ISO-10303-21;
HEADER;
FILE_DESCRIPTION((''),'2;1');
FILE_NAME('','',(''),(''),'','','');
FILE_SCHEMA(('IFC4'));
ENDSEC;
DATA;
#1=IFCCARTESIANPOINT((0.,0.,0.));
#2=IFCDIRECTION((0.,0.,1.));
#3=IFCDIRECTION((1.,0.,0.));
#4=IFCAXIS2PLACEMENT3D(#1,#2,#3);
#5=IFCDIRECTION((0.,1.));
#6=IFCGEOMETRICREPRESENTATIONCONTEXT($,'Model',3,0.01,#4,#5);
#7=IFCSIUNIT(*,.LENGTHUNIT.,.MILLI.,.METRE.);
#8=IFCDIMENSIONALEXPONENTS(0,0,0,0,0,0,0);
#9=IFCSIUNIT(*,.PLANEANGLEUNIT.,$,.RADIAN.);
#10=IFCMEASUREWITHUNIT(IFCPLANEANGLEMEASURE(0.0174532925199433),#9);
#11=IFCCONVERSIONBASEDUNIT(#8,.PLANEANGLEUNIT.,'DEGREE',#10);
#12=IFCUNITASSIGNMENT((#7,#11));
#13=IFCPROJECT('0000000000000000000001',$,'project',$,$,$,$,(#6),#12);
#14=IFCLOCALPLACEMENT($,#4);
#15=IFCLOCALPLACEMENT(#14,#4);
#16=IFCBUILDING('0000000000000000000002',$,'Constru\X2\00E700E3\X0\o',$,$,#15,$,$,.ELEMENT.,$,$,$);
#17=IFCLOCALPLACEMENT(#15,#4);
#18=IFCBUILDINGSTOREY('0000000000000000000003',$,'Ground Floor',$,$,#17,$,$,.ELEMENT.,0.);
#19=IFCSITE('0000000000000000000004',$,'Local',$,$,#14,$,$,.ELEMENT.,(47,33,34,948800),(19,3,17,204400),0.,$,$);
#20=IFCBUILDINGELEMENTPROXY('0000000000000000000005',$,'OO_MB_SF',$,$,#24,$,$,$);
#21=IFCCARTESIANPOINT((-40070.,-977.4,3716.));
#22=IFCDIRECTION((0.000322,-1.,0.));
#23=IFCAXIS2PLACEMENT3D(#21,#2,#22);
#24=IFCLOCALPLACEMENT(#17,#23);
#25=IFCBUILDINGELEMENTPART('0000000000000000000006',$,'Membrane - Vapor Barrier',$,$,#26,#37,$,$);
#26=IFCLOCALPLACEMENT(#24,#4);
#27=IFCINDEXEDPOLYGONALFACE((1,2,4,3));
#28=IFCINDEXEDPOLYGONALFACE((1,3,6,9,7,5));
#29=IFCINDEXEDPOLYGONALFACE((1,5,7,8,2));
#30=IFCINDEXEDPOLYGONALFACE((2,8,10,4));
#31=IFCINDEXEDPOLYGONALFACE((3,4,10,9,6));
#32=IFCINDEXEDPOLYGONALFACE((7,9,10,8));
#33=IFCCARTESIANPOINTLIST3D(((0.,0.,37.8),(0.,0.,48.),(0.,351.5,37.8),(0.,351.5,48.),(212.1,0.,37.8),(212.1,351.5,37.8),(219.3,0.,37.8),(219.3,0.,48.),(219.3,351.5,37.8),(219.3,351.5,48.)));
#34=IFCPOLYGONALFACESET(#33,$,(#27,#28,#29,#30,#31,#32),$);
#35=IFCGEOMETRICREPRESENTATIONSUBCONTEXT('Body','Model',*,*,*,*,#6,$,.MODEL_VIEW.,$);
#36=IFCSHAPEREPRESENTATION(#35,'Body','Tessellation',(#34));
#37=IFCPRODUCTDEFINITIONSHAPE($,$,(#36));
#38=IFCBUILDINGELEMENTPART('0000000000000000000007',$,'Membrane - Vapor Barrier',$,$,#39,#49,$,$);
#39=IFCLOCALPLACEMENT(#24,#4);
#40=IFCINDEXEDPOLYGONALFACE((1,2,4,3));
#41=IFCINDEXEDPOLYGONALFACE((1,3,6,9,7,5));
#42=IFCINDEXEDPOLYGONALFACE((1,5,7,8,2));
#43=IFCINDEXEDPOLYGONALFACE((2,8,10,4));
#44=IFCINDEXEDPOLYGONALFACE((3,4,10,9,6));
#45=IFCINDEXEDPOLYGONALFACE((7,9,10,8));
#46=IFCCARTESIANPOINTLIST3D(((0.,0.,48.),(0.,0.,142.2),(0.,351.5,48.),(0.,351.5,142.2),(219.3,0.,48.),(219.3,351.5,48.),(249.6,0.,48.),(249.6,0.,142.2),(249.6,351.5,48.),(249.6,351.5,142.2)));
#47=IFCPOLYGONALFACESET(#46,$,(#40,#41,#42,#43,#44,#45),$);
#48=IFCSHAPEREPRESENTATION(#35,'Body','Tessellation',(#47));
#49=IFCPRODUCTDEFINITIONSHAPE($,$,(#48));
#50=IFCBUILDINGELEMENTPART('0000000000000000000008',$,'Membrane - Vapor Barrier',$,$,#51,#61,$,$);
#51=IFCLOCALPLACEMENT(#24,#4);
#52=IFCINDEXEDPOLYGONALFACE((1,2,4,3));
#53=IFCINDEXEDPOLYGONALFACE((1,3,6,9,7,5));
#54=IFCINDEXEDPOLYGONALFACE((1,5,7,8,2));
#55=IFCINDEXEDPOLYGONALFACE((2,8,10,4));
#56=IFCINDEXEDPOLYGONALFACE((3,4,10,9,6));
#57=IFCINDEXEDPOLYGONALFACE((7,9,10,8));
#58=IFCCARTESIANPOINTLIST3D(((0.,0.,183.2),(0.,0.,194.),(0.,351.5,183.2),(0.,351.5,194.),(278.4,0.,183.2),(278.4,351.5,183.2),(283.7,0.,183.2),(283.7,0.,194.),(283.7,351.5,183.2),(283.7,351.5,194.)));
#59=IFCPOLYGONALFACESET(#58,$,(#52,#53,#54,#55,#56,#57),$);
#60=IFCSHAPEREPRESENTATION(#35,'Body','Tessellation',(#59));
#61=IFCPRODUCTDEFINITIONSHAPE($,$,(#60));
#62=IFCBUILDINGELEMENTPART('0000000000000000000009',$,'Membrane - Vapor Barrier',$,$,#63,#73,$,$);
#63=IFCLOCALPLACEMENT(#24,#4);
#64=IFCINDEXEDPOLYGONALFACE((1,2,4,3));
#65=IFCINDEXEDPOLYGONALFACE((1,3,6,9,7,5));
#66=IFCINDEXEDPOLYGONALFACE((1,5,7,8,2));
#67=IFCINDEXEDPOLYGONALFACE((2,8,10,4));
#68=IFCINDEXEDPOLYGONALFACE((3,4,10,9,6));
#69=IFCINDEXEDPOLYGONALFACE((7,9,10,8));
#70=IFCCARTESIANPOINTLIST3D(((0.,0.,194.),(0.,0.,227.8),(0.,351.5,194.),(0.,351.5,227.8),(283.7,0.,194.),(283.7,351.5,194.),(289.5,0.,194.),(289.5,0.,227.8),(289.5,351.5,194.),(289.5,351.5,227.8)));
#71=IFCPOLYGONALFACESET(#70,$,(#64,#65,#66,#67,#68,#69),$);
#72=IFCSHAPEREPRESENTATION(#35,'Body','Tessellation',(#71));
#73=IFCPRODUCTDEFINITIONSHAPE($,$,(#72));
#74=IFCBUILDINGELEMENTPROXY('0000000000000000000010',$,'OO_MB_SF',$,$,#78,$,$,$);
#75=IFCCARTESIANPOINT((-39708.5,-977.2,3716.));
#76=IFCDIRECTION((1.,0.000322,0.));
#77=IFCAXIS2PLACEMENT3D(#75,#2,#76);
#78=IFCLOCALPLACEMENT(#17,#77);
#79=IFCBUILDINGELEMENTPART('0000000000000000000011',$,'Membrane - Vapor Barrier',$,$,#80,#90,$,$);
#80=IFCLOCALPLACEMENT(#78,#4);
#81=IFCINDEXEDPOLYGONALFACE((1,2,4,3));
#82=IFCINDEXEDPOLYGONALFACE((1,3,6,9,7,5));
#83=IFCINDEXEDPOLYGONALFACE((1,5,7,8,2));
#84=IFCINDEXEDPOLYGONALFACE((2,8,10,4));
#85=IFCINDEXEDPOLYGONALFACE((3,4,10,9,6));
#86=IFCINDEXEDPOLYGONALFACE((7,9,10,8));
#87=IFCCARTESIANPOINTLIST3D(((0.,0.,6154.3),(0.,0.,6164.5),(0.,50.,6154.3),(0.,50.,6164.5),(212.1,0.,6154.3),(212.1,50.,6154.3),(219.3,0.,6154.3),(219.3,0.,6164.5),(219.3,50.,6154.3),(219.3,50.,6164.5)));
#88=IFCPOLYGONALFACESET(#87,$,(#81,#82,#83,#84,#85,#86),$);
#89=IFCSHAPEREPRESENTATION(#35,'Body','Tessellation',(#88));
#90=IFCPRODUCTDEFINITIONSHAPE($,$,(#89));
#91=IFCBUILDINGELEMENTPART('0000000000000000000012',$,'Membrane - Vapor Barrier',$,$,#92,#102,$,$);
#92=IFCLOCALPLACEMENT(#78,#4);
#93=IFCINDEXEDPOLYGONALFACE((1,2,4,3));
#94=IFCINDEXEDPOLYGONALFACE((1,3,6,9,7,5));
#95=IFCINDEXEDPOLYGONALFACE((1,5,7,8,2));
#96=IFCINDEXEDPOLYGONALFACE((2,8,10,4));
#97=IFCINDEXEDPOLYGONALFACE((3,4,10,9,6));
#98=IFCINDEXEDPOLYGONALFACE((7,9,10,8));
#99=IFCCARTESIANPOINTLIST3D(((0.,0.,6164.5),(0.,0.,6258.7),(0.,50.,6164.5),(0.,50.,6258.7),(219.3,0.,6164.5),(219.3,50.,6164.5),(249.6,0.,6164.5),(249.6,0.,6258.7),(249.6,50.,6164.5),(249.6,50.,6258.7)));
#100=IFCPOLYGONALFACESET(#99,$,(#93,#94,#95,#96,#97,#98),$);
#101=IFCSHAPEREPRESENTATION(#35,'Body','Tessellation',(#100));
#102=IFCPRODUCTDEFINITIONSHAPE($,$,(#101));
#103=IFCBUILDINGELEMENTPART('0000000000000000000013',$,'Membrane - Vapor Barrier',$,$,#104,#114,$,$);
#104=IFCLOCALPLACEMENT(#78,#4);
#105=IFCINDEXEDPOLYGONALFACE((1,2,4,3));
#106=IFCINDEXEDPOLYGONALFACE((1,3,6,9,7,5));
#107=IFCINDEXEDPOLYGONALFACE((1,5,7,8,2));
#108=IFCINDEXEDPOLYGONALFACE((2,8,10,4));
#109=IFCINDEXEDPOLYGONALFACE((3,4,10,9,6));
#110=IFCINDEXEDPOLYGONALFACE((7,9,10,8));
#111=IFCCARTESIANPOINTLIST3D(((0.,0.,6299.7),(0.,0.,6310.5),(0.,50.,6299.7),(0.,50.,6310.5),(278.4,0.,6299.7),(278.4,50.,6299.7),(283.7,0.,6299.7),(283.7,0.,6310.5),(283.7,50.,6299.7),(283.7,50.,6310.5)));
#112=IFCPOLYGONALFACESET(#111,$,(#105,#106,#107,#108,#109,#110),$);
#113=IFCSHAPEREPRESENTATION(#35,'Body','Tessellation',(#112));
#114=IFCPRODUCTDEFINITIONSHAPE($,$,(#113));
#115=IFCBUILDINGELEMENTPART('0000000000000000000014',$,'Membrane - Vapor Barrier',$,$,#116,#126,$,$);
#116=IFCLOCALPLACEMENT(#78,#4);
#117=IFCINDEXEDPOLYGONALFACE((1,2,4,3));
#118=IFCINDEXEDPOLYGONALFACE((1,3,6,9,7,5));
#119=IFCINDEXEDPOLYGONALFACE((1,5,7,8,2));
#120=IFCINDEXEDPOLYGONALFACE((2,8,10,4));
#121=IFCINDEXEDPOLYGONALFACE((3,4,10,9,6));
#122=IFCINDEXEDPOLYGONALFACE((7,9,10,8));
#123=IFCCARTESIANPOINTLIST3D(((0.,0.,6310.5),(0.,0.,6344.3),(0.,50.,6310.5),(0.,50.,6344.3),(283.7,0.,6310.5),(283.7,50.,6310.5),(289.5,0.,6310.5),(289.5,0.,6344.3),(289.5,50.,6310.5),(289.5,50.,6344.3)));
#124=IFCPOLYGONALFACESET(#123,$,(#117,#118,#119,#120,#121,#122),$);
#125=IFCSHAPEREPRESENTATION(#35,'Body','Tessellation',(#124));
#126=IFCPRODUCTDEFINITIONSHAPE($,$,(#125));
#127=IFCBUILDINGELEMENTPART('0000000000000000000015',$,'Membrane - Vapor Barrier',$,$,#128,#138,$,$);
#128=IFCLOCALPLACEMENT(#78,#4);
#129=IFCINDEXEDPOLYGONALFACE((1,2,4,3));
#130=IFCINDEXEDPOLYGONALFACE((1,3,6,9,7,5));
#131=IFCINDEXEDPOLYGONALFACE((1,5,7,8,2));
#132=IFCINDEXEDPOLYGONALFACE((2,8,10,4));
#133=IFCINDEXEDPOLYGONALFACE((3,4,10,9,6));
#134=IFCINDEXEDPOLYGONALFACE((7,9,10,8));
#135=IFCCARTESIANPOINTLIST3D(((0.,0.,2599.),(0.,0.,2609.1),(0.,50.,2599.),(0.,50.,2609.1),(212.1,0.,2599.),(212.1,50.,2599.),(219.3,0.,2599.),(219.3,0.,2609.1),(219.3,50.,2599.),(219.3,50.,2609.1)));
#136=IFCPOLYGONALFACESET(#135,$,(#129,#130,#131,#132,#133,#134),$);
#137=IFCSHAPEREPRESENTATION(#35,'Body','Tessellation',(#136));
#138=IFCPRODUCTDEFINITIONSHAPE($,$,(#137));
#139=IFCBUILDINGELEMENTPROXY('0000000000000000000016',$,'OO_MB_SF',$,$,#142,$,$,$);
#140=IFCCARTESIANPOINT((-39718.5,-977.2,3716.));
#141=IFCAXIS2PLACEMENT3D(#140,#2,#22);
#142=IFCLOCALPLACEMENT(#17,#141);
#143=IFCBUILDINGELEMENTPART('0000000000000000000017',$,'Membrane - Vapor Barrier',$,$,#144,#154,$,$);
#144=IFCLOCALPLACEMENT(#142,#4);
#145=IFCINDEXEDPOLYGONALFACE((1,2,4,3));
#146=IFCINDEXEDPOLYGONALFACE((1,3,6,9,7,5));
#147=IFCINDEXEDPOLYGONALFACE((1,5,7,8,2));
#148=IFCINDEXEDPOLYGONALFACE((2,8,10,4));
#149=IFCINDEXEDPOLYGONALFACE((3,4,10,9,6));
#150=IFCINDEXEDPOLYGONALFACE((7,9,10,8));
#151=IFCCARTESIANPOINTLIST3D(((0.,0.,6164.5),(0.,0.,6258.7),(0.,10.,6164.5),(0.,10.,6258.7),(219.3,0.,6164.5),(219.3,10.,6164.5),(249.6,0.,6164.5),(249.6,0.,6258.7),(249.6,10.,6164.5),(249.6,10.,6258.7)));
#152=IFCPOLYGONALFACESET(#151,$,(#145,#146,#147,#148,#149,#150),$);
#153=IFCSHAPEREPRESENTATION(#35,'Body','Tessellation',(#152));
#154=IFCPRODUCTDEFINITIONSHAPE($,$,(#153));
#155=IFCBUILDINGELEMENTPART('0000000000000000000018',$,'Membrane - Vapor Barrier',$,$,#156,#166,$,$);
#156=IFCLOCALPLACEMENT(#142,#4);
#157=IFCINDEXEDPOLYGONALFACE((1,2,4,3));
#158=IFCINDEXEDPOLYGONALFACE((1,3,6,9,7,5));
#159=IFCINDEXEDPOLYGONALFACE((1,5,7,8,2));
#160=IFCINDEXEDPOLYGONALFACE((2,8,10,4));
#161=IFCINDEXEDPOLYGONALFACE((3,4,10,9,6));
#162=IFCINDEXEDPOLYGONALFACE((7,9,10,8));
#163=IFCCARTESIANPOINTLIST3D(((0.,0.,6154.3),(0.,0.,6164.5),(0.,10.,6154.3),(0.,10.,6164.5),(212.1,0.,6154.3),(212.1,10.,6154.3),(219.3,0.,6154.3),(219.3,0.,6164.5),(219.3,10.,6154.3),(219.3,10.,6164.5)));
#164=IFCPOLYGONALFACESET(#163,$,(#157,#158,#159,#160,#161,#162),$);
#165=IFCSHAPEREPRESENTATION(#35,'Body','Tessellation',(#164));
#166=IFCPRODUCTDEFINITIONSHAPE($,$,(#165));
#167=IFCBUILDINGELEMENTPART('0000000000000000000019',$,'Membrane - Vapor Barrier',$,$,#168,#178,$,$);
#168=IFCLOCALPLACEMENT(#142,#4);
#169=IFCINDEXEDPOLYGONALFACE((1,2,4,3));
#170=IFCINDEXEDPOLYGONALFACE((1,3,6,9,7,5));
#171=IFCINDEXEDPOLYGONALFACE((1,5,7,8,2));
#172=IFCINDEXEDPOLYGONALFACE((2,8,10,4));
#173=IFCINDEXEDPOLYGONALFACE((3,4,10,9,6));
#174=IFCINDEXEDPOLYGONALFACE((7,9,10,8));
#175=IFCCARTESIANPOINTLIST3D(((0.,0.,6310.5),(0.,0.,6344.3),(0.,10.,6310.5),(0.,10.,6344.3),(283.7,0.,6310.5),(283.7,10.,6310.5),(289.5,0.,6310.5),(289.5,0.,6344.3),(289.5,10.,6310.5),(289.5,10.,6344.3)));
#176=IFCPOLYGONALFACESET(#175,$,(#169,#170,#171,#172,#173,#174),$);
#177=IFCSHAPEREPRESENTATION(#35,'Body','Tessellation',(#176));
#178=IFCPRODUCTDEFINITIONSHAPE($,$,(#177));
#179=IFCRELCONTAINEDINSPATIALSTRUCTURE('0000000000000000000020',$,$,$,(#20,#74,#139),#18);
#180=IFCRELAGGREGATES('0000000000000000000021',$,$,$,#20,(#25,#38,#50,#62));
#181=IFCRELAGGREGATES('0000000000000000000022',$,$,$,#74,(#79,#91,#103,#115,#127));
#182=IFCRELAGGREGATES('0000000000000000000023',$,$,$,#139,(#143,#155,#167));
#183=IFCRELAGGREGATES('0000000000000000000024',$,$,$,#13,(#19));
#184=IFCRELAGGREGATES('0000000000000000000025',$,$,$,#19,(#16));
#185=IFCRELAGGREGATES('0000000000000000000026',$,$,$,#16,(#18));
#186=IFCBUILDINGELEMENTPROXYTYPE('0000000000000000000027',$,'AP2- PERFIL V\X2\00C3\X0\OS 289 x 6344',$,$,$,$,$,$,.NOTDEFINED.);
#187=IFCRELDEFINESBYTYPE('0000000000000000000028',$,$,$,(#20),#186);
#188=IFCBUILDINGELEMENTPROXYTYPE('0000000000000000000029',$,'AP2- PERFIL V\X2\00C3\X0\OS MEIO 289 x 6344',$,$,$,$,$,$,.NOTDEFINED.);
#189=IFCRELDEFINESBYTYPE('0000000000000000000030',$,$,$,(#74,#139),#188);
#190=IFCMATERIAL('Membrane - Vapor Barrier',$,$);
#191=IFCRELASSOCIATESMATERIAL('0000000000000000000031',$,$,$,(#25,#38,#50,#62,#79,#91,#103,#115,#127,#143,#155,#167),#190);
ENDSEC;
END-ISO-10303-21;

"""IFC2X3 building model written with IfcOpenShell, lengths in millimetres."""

from ifc_helpers import new_model, entity, si_unit, converted_unit, direction, frame, origin_with_axes, place, context, subcontext, project, spatial, polyline, outline, extrude, material, type_object, element, aggregate, save


model = new_model("IFC2X3")

# Units and contexts
model_context = context("Model", 3, precision=0.01, world=origin_with_axes(), true_north=direction((0.0, 1.0)))
body_context = subcontext(model_context, "Body", "Model", "MODEL_VIEW")
ifc_project = project(units=[si_unit("LENGTHUNIT", "METRE", prefix="MILLI"), converted_unit("PLANEANGLEUNIT", "DEGREE", entity("IfcPlaneAngleMeasure", 0.0174532925199433), si_unit("PLANEANGLEUNIT", "RADIAN"), dimensions=[0, 0, 0, 0, 0, 0, 0])], contexts=[model_context])

# Site, building, storey
site_placement = place(None, origin_with_axes())
site = spatial("IfcSite", under=ifc_project, at=site_placement, Name="Local", CompositionType="ELEMENT", RefLatitude=(47, 33, 34, 948800), RefLongitude=(19, 3, 17, 204400), RefElevation=0.0)
building_placement = place(site_placement, origin_with_axes())
building = spatial("IfcBuilding", under=site, at=building_placement, Name="Construção", CompositionType="ELEMENT")
storey_placement = place(building_placement, origin_with_axes())
storey = spatial("IfcBuildingStorey", under=building, at=storey_placement, Name="Ground Floor", CompositionType="ELEMENT", Elevation=0.0)

# Building element proxies, building element parts
building_element_proxy_type_1 = type_object("IfcBuildingElementProxyType", Name="AP2- PERFIL VÃOS 289 x 6344", PredefinedType="NOTDEFINED")
proxy_1_placement = place(storey_placement, frame((-40070.0, -977.4, 3716.0), z_axis=(0.0, 0.0, 1.0), x_axis=(0.000322, -1.0, 0.0)))
proxy_1 = element("IfcBuildingElementProxy", 1, at=proxy_1_placement, inside=storey, type_object=building_element_proxy_type_1, Name="OO_MB_SF")
ifc_material_1 = material(Name="Membrane - Vapor Barrier")
building_element_part_1_placement = place(proxy_1_placement, origin_with_axes())
building_element_part_1 = element("IfcBuildingElementPart", 2, at=building_element_part_1_placement, material=ifc_material_1, Name="Membrane - Vapor Barrier", context=body_context, shape_type="SweptSolid", body=[
    extrude(outline(polyline([(0.0, 37.8), (212.1, 37.8), (219.3, 37.8), (219.3, 48.0), (0.0, 48.0), (0.0, 37.8)])), frame((0.0, 351.5, 0.0), z_axis=(0.0, -1.0, 0.0), x_axis=(1.0, 0.0, 0.0)), (0.0, 0.0, 1.0), 351.5),
])
building_element_part_2_placement = place(proxy_1_placement, origin_with_axes())
building_element_part_2 = element("IfcBuildingElementPart", 3, at=building_element_part_2_placement, material=ifc_material_1, Name="Membrane - Vapor Barrier", context=body_context, shape_type="SweptSolid", body=[
    extrude(outline(polyline([(249.6, 142.2), (0.0, 142.2), (0.0, 48.0), (219.3, 48.0), (249.6, 48.0), (249.6, 142.2)])), frame((0.0, 351.5, 0.0), z_axis=(0.0, -1.0, 0.0), x_axis=(1.0, 0.0, 0.0)), (0.0, 0.0, 1.0), 351.5),
])
building_element_part_3_placement = place(proxy_1_placement, origin_with_axes())
building_element_part_3 = element("IfcBuildingElementPart", 4, at=building_element_part_3_placement, material=ifc_material_1, Name="Membrane - Vapor Barrier", context=body_context, shape_type="SweptSolid", body=[
    extrude(outline(polyline([(0.0, 183.2), (278.4, 183.2), (283.7, 183.2), (283.7, 194.0), (0.0, 194.0), (0.0, 183.2)])), frame((0.0, 351.5, 0.0), z_axis=(0.0, -1.0, 0.0), x_axis=(1.0, 0.0, 0.0)), (0.0, 0.0, 1.0), 351.5),
])
building_element_part_4_placement = place(proxy_1_placement, origin_with_axes())
building_element_part_4 = element("IfcBuildingElementPart", 5, at=building_element_part_4_placement, material=ifc_material_1, Name="Membrane - Vapor Barrier", context=body_context, shape_type="SweptSolid", body=[
    extrude(outline(polyline([(0.0, 194.0), (283.7, 194.0), (289.5, 194.0), (289.5, 227.8), (0.0, 227.8), (0.0, 194.0)])), frame((0.0, 351.5, 0.0), z_axis=(0.0, -1.0, 0.0), x_axis=(1.0, 0.0, 0.0)), (0.0, 0.0, 1.0), 351.5),
])
aggregate(proxy_1, [building_element_part_1, building_element_part_2, building_element_part_3, building_element_part_4])
building_element_proxy_type_2 = type_object("IfcBuildingElementProxyType", Name="AP2- PERFIL VÃOS MEIO 289 x 6344", PredefinedType="NOTDEFINED")
proxy_2_placement = place(storey_placement, frame((-39708.5, -977.2, 3716.0), z_axis=(0.0, 0.0, 1.0), x_axis=(1.0, 0.000322, 0.0)))
proxy_2 = element("IfcBuildingElementProxy", 6, at=proxy_2_placement, inside=storey, type_object=building_element_proxy_type_2, Name="OO_MB_SF")
building_element_part_5_placement = place(proxy_2_placement, origin_with_axes())
building_element_part_5 = element("IfcBuildingElementPart", 7, at=building_element_part_5_placement, material=ifc_material_1, Name="Membrane - Vapor Barrier", context=body_context, shape_type="SweptSolid", body=[
    extrude(outline(polyline([(0.0, 6154.3), (212.1, 6154.3), (219.3, 6154.3), (219.3, 6164.5), (0.0, 6164.5), (0.0, 6154.3)])), frame((0.0, 50.0, 0.0), z_axis=(0.0, -1.0, 0.0), x_axis=(1.0, 0.0, 0.0)), (0.0, 0.0, 1.0), 50.0),
])
building_element_part_6_placement = place(proxy_2_placement, origin_with_axes())
building_element_part_6 = element("IfcBuildingElementPart", 8, at=building_element_part_6_placement, material=ifc_material_1, Name="Membrane - Vapor Barrier", context=body_context, shape_type="SweptSolid", body=[
    extrude(outline(polyline([(249.6, 6258.7), (0.0, 6258.7), (0.0, 6164.5), (219.3, 6164.5), (249.6, 6164.5), (249.6, 6258.7)])), frame((0.0, 50.0, 0.0), z_axis=(0.0, -1.0, 0.0), x_axis=(1.0, 0.0, 0.0)), (0.0, 0.0, 1.0), 50.0),
])
building_element_part_7_placement = place(proxy_2_placement, origin_with_axes())
building_element_part_7 = element("IfcBuildingElementPart", 9, at=building_element_part_7_placement, material=ifc_material_1, Name="Membrane - Vapor Barrier", context=body_context, shape_type="SweptSolid", body=[
    extrude(outline(polyline([(0.0, 6299.7), (278.4, 6299.7), (283.7, 6299.7), (283.7, 6310.5), (0.0, 6310.5), (0.0, 6299.7)])), frame((0.0, 50.0, 0.0), z_axis=(0.0, -1.0, 0.0), x_axis=(1.0, 0.0, 0.0)), (0.0, 0.0, 1.0), 50.0),
])
building_element_part_8_placement = place(proxy_2_placement, origin_with_axes())
building_element_part_8 = element("IfcBuildingElementPart", 10, at=building_element_part_8_placement, material=ifc_material_1, Name="Membrane - Vapor Barrier", context=body_context, shape_type="SweptSolid", body=[
    extrude(outline(polyline([(0.0, 6310.5), (283.7, 6310.5), (289.5, 6310.5), (289.5, 6344.3), (0.0, 6344.3), (0.0, 6310.5)])), frame((0.0, 50.0, 0.0), z_axis=(0.0, -1.0, 0.0), x_axis=(1.0, 0.0, 0.0)), (0.0, 0.0, 1.0), 50.0),
])
building_element_part_9_placement = place(proxy_2_placement, origin_with_axes())
building_element_part_9 = element("IfcBuildingElementPart", 11, at=building_element_part_9_placement, material=ifc_material_1, Name="Membrane - Vapor Barrier", context=body_context, shape_type="SweptSolid", body=[
    extrude(outline(polyline([(0.0, 2599.0), (212.1, 2599.0), (219.3, 2599.0), (219.3, 2609.1), (0.0, 2609.1), (0.0, 2599.0)])), frame((0.0, 50.0, 0.0), z_axis=(0.0, -1.0, 0.0), x_axis=(1.0, 0.0, 0.0)), (0.0, 0.0, 1.0), 50.0),
])
aggregate(proxy_2, [building_element_part_5, building_element_part_6, building_element_part_7, building_element_part_8, building_element_part_9])
proxy_3_placement = place(storey_placement, frame((-39718.5, -977.2, 3716.0), z_axis=(0.0, 0.0, 1.0), x_axis=(0.000322, -1.0, 0.0)))
proxy_3 = element("IfcBuildingElementProxy", 12, at=proxy_3_placement, inside=storey, type_object=building_element_proxy_type_2, Name="OO_MB_SF")
building_element_part_10_placement = place(proxy_3_placement, origin_with_axes())
building_element_part_10 = element("IfcBuildingElementPart", 13, at=building_element_part_10_placement, material=ifc_material_1, Name="Membrane - Vapor Barrier", context=body_context, shape_type="SweptSolid", body=[
    extrude(outline(polyline([(249.6, 6258.7), (0.0, 6258.7), (0.0, 6164.5), (219.3, 6164.5), (249.6, 6164.5), (249.6, 6258.7)])), frame((0.0, 10.0, 0.0), z_axis=(0.0, -1.0, 0.0), x_axis=(1.0, 0.0, 0.0)), (0.0, 0.0, 1.0), 10.0),
])
building_element_part_11_placement = place(proxy_3_placement, origin_with_axes())
building_element_part_11 = element("IfcBuildingElementPart", 14, at=building_element_part_11_placement, material=ifc_material_1, Name="Membrane - Vapor Barrier", context=body_context, shape_type="SweptSolid", body=[
    extrude(outline(polyline([(0.0, 6154.3), (212.1, 6154.3), (219.3, 6154.3), (219.3, 6164.5), (0.0, 6164.5), (0.0, 6154.3)])), frame((0.0, 10.0, 0.0), z_axis=(0.0, -1.0, 0.0), x_axis=(1.0, 0.0, 0.0)), (0.0, 0.0, 1.0), 10.0),
])
building_element_part_12_placement = place(proxy_3_placement, origin_with_axes())
building_element_part_12 = element("IfcBuildingElementPart", 15, at=building_element_part_12_placement, material=ifc_material_1, Name="Membrane - Vapor Barrier", context=body_context, shape_type="SweptSolid", body=[
    extrude(outline(polyline([(0.0, 6310.5), (283.7, 6310.5), (289.5, 6310.5), (289.5, 6344.3), (0.0, 6344.3), (0.0, 6310.5)])), frame((0.0, 10.0, 0.0), z_axis=(0.0, -1.0, 0.0), x_axis=(1.0, 0.0, 0.0)), (0.0, 0.0, 1.0), 10.0),
])
aggregate(proxy_3, [building_element_part_10, building_element_part_11, building_element_part_12])

save(model, "model.ifc")
